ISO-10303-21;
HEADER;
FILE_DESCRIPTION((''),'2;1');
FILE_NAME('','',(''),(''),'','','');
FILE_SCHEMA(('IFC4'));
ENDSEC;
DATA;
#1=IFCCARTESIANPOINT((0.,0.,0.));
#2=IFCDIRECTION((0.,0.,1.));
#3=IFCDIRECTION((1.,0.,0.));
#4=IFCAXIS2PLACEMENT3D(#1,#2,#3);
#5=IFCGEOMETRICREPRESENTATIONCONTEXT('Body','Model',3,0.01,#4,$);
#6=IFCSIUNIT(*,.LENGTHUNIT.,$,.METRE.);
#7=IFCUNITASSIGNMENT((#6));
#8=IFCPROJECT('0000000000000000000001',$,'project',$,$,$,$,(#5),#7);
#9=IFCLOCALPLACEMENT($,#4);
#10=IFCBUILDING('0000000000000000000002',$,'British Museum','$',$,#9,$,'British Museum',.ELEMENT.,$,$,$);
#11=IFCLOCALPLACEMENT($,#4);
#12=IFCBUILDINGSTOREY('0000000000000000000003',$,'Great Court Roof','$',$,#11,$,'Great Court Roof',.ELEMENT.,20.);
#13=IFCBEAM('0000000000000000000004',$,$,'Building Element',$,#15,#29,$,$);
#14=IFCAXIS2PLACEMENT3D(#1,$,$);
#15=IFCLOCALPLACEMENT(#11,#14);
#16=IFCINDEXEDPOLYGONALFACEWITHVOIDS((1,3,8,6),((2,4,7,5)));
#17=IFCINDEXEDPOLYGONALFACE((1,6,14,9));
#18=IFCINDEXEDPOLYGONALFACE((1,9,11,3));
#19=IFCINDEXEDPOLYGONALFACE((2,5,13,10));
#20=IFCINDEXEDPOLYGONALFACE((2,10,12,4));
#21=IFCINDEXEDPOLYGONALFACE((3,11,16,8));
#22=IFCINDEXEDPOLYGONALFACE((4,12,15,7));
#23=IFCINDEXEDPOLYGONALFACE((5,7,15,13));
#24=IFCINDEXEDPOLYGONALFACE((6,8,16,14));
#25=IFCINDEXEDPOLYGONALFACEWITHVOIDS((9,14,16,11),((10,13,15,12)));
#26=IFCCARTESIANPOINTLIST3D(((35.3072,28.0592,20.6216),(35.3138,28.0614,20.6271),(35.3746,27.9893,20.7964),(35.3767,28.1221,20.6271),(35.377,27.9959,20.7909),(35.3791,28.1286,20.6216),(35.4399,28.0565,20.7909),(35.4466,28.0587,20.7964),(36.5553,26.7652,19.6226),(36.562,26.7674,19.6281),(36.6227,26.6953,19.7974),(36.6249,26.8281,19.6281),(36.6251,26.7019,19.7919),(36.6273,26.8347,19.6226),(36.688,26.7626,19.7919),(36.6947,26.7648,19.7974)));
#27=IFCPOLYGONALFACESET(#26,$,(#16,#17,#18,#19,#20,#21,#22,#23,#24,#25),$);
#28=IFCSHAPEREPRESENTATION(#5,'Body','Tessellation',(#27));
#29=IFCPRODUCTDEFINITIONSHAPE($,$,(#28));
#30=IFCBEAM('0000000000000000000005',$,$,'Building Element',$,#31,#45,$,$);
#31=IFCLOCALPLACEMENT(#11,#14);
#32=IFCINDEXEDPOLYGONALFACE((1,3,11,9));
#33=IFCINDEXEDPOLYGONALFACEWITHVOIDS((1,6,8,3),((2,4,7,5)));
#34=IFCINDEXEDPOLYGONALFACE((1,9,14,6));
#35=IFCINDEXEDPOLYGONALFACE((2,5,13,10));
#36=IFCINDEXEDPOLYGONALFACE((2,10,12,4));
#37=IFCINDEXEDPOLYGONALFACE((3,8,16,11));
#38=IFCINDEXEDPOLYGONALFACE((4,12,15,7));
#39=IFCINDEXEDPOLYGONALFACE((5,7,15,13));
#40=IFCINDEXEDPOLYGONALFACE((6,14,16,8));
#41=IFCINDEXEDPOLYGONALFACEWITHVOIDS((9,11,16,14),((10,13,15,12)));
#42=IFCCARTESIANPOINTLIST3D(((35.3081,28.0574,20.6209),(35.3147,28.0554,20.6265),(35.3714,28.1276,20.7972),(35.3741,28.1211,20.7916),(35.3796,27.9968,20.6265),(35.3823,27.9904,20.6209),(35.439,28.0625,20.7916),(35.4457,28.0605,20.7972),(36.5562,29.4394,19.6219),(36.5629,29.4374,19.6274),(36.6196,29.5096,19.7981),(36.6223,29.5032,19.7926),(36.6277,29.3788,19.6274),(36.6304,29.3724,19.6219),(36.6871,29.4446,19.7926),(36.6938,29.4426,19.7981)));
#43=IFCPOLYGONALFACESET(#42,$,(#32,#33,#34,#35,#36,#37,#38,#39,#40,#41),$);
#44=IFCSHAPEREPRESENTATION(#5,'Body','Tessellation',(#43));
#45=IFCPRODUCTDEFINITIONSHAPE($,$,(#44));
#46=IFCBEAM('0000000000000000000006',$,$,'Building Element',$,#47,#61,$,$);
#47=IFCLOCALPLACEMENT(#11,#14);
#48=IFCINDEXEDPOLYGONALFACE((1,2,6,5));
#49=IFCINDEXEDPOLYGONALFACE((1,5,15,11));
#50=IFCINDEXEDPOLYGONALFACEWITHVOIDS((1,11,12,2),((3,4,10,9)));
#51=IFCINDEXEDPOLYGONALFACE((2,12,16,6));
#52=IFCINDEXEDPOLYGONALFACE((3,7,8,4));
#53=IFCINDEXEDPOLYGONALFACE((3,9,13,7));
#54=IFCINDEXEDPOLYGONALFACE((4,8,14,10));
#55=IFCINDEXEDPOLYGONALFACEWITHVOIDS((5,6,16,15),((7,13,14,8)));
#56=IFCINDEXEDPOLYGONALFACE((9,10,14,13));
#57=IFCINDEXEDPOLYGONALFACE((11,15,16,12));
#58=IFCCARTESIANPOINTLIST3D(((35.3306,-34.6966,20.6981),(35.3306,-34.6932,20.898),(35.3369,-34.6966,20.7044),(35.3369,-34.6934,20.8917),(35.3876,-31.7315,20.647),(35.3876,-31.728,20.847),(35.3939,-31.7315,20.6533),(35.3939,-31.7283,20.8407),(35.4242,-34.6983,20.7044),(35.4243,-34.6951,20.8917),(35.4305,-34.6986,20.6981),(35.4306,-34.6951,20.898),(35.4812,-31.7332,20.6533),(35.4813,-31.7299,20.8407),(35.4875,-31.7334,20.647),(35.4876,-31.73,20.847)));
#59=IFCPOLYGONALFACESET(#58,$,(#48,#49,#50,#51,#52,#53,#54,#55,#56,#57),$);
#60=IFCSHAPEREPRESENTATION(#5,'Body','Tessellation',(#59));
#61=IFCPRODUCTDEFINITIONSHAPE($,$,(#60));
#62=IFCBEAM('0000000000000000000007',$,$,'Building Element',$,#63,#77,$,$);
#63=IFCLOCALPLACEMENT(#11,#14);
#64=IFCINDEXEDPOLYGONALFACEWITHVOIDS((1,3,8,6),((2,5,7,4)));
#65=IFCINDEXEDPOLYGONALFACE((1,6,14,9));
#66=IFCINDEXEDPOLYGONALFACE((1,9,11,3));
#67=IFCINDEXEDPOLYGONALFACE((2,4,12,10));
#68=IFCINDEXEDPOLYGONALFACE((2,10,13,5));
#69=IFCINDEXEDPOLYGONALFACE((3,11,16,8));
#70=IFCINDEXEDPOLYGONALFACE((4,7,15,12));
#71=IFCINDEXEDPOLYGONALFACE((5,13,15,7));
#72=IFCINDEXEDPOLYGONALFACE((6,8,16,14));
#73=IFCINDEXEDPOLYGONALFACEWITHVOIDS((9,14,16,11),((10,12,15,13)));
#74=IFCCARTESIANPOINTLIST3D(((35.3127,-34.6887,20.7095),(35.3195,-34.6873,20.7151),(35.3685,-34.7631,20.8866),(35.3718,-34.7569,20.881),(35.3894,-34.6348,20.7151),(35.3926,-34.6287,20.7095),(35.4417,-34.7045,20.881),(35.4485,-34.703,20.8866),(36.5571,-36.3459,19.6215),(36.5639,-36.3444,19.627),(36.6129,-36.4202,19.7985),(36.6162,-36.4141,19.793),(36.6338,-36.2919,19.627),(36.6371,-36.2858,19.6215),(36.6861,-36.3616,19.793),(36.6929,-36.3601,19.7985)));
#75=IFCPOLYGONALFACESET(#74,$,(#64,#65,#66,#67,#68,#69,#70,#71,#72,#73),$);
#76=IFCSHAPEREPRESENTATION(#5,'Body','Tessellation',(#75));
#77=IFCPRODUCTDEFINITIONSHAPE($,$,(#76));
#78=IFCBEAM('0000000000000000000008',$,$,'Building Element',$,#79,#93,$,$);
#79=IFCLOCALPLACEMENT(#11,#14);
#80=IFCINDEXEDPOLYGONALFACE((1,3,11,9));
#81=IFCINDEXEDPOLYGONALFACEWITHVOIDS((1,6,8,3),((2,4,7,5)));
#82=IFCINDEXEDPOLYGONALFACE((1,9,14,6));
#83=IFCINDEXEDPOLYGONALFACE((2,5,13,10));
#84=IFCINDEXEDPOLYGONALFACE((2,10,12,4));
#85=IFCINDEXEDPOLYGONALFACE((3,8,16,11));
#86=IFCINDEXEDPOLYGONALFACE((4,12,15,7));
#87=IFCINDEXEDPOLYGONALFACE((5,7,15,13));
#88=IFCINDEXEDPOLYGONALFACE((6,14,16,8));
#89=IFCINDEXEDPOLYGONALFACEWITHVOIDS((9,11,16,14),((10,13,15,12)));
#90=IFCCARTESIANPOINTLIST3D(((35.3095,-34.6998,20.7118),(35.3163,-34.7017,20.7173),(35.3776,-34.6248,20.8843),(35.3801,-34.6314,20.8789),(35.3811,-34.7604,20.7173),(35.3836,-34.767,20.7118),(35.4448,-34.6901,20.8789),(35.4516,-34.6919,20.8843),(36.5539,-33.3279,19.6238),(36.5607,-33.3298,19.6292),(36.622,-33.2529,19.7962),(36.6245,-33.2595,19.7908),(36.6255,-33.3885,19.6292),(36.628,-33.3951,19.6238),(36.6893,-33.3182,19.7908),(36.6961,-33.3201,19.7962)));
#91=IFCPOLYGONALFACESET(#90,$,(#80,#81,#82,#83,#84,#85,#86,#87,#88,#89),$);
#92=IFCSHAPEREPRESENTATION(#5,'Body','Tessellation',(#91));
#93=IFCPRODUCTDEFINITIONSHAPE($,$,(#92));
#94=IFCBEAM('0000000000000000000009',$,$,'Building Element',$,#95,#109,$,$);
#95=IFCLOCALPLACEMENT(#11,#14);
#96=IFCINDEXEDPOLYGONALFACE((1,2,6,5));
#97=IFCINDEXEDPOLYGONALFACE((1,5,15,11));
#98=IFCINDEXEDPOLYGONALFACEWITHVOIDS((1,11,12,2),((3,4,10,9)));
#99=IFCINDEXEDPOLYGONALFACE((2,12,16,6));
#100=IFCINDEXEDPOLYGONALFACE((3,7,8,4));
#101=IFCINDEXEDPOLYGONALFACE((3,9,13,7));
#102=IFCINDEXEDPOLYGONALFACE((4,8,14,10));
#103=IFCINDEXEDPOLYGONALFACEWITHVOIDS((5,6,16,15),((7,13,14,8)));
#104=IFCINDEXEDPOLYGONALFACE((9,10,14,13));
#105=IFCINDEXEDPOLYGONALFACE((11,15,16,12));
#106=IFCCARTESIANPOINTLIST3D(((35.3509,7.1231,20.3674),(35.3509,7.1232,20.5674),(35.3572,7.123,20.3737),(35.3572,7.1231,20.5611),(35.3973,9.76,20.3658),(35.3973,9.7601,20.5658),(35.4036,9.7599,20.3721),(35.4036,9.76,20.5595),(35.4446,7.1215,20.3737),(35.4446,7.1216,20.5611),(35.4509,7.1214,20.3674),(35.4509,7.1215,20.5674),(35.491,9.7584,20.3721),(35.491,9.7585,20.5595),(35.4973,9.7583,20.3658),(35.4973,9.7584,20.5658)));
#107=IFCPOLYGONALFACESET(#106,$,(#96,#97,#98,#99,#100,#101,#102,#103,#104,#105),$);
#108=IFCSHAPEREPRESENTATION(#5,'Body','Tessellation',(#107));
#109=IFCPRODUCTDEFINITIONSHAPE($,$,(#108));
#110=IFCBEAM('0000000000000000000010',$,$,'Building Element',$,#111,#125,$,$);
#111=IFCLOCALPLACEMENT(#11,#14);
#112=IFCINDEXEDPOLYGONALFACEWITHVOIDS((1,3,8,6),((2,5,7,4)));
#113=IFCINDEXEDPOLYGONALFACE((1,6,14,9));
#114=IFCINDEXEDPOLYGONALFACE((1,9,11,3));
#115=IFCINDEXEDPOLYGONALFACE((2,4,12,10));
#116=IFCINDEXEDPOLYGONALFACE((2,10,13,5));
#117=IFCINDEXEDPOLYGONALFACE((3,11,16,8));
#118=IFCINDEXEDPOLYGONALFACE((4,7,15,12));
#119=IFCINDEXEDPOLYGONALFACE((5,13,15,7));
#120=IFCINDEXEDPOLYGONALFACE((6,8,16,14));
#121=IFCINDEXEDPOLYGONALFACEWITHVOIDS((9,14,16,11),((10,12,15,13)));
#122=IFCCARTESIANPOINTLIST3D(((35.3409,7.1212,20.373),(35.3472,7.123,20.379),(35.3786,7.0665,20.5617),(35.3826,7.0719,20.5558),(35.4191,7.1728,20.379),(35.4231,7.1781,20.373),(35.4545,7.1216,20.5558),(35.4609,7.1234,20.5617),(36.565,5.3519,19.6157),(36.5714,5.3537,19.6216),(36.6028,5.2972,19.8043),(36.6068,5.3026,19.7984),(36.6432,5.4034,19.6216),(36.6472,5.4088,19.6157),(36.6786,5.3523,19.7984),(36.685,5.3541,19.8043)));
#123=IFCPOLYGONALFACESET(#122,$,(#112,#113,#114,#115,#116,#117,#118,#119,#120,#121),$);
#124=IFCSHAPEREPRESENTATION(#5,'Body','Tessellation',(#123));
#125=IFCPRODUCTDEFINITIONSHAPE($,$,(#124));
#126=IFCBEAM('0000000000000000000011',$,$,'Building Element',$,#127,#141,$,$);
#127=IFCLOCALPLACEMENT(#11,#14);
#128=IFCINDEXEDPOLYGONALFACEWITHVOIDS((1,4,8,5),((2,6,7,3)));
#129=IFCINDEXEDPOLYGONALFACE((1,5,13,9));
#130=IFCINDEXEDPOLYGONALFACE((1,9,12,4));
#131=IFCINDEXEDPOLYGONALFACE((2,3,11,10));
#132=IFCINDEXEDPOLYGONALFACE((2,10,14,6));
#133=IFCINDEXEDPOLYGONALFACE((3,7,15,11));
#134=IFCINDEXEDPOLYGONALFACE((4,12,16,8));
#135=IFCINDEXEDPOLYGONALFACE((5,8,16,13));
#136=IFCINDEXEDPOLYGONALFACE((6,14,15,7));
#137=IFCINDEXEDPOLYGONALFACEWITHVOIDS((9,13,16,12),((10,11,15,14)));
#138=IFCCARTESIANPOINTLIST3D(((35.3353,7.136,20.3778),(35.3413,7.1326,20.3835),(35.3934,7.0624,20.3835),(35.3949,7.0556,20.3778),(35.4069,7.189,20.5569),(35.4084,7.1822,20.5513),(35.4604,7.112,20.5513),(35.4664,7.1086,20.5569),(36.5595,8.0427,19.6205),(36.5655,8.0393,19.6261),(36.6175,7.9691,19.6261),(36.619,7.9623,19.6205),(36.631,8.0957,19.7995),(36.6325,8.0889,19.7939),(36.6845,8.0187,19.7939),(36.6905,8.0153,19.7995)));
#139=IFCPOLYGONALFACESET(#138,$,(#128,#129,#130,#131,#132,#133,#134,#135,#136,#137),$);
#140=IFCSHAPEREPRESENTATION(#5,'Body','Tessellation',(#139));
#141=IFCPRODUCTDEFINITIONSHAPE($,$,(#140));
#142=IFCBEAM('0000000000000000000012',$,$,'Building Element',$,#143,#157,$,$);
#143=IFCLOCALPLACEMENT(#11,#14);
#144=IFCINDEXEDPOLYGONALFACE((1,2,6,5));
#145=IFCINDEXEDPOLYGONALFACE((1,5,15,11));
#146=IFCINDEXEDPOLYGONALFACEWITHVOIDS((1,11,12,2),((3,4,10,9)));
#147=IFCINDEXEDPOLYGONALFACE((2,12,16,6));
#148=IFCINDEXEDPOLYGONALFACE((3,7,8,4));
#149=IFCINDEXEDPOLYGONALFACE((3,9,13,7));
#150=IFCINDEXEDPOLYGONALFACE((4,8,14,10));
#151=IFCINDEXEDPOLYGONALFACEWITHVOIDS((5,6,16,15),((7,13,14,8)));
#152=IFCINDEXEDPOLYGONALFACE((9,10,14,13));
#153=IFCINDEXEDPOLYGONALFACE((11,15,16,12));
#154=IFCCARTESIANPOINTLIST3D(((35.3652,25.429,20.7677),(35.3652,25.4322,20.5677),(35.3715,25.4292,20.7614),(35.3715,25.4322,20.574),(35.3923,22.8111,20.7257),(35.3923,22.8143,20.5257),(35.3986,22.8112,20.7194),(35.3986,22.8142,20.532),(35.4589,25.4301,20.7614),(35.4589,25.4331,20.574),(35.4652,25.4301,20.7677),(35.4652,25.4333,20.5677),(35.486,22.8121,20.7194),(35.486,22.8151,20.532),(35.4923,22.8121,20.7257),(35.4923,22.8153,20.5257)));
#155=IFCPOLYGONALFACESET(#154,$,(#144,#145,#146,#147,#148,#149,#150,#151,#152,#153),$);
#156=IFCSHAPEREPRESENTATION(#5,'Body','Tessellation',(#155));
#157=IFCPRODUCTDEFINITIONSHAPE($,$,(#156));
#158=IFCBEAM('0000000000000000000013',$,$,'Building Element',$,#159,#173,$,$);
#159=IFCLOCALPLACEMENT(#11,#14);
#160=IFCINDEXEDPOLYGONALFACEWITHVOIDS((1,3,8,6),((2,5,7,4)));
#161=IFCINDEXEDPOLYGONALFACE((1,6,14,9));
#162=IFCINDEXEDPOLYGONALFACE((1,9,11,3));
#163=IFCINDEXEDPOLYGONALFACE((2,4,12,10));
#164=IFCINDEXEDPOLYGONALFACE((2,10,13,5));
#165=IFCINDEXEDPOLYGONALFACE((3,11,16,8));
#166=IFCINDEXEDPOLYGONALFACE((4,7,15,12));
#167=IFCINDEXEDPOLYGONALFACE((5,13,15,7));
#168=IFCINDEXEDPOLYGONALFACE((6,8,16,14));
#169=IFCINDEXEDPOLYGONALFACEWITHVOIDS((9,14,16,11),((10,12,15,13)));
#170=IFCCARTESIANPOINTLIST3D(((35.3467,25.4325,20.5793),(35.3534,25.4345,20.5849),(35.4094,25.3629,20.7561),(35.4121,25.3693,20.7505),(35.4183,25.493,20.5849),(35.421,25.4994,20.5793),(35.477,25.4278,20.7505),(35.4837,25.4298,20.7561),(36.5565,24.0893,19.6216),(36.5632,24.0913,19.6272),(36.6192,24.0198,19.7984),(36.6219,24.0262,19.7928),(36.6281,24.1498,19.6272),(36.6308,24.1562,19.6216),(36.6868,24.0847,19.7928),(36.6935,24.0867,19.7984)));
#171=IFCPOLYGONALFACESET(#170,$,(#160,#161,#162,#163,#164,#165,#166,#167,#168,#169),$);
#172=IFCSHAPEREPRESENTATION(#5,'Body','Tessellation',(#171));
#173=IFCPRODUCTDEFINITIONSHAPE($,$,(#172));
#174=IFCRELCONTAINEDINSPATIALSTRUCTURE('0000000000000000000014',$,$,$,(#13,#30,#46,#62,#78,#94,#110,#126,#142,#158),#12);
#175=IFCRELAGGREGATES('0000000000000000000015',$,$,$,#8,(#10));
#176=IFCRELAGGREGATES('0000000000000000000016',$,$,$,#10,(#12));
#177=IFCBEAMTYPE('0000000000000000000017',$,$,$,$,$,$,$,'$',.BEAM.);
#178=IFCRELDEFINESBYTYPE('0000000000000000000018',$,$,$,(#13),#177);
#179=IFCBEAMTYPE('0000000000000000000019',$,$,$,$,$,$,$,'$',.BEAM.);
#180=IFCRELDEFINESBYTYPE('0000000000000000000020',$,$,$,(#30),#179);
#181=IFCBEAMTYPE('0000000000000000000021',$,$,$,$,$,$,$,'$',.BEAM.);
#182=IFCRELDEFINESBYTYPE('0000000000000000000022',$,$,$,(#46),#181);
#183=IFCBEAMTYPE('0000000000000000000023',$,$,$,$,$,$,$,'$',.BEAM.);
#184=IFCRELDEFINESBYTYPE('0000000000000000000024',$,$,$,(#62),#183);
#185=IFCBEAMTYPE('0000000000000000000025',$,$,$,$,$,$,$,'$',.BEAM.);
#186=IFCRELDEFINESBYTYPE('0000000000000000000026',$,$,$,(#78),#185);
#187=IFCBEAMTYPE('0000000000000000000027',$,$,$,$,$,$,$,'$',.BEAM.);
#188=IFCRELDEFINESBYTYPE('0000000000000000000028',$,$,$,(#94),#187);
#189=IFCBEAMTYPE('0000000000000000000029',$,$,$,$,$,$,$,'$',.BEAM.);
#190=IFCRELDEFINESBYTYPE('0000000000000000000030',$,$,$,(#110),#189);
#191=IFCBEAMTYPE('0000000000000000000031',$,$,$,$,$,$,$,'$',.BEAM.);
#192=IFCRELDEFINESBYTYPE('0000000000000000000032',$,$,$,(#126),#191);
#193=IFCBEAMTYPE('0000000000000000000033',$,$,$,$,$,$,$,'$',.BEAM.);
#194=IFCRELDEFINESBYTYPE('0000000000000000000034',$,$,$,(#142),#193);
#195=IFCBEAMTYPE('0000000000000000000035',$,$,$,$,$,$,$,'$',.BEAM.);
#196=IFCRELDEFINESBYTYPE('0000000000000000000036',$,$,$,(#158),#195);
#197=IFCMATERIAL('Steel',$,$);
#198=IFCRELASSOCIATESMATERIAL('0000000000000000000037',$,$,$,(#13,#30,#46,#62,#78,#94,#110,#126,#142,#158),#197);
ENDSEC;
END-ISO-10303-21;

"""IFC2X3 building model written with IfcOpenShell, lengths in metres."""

from ifc_helpers import new_model, si_unit, frame, origin_with_axes, origin_2d, place, context, project, spatial, hollow_rectangle, extrude, material, type_object, element, save


model = new_model("IFC2X3")

# Units and contexts
model_context = context("Model", 3, precision=0.01, world=origin_with_axes(), identifier="Body")
ifc_project = project(units=[si_unit("LENGTHUNIT", "METRE")], contexts=[model_context])

# Building, storey
building_placement = place(None, origin_with_axes())
building = spatial("IfcBuilding", under=ifc_project, at=building_placement, Name="British Museum", Description="$", LongName="British Museum", CompositionType="ELEMENT")
storey_placement = place(None, origin_with_axes())
storey = spatial("IfcBuildingStorey", under=building, at=storey_placement, Name="Great Court Roof", Description="$", LongName="Great Court Roof", CompositionType="ELEMENT", Elevation=20.0)

# Beams
ifc_material = material(Name="Steel")
beam_type_1 = type_object("IfcBeamType", ElementType="$", PredefinedType="BEAM")
beam_1_placement = place(None, origin_with_axes())
element("IfcBeam", 1, at=beam_1_placement, inside=storey, type_object=beam_type_1, material=ifc_material, Description="Building Element", context=model_context, shape_type="SweptSolid", body=[
    extrude(hollow_rectangle(XDim=0.1, YDim=0.2, WallThickness=0.0063, InnerFilletRadius=0.0, OuterFilletRadius=0.0, at=origin_2d()), frame((35.3769, 28.059, 20.709), z_axis=(0.606845, -0.629129, -0.485733), x_axis=(0.719738, 0.694245, 0.0)), (0.0, 0.0, 1.0), 2.0568),
])
beam_type_2 = type_object("IfcBeamType", ElementType="$", PredefinedType="BEAM")
beam_2_placement = place(None, origin_with_axes())
element("IfcBeam", 2, at=beam_2_placement, inside=storey, type_object=beam_type_2, material=ifc_material, Description="Building Element", context=model_context, shape_type="SweptSolid", body=[
    extrude(hollow_rectangle(XDim=0.1, YDim=0.2, WallThickness=0.0063, InnerFilletRadius=0.0, OuterFilletRadius=0.0, at=origin_2d()), frame((35.3769, 28.059, 20.709), z_axis=(0.590615, 0.65398, -0.472742), x_axis=(-0.742146, 0.670239, 0.0)), (0.0, 0.0, 1.0), 2.1133),
])
beam_type_3 = type_object("IfcBeamType", ElementType="$", PredefinedType="BEAM")
beam_3_placement = place(None, origin_with_axes())
element("IfcBeam", 3, at=beam_3_placement, inside=storey, type_object=beam_type_3, material=ifc_material, Description="Building Element", context=model_context, shape_type="SweptSolid", body=[
    extrude(hollow_rectangle(XDim=0.1, YDim=0.2, WallThickness=0.0063, InnerFilletRadius=0.0, OuterFilletRadius=0.0, at=origin_2d()), frame((35.3806, -34.6959, 20.7981), z_axis=(0.019218, 0.999667, -0.017217), x_axis=(-0.999815, 0.019221, 0.0)), (0.0, 0.0, 1.0), 2.9661),
])
beam_type_4 = type_object("IfcBeamType", ElementType="$", PredefinedType="BEAM")
beam_4_placement = place(None, origin_with_axes())
element("IfcBeam", 4, at=beam_4_placement, inside=storey, type_object=beam_type_4, material=ifc_material, Description="Building Element", context=model_context, shape_type="SweptSolid", body=[
    extrude(hollow_rectangle(XDim=0.1, YDim=0.2, WallThickness=0.0063, InnerFilletRadius=0.0, OuterFilletRadius=0.0, at=origin_2d()), frame((35.3806, -34.6959, 20.7981), z_axis=(0.531661, -0.707985, -0.46486), x_axis=(0.799636, 0.600486, 0.0)), (0.0, 0.0, 1.0), 2.3406),
])
beam_type_5 = type_object("IfcBeamType", ElementType="$", PredefinedType="BEAM")
beam_5_placement = place(None, origin_with_axes())
element("IfcBeam", 5, at=beam_5_placement, inside=storey, type_object=beam_type_5, material=ifc_material, Description="Building Element", context=model_context, shape_type="SweptSolid", body=[
    extrude(hollow_rectangle(XDim=0.1, YDim=0.2, WallThickness=0.0063, InnerFilletRadius=0.0, OuterFilletRadius=0.0, at=origin_2d()), frame((35.3806, -34.6959, 20.7981), z_axis=(0.579301, 0.638633, -0.506515), x_axis=(-0.740675, 0.671863, 0.0)), (0.0, 0.0, 1.0), 2.1481),
])
beam_type_6 = type_object("IfcBeamType", ElementType="$", PredefinedType="BEAM")
beam_6_placement = place(None, origin_with_axes())
element("IfcBeam", 6, at=beam_6_placement, inside=storey, type_object=beam_type_6, material=ifc_material, Description="Building Element", context=model_context, shape_type="SweptSolid", body=[
    extrude(hollow_rectangle(XDim=0.1, YDim=0.2, WallThickness=0.0063, InnerFilletRadius=0.0, OuterFilletRadius=0.0, at=origin_2d()), frame((35.4009, 7.1223, 20.4674), z_axis=(0.01761, 0.999845, -0.000584), x_axis=(-0.999845, 0.01761, 0.0)), (0.0, 0.0, 1.0), 2.6373),
])
beam_type_7 = type_object("IfcBeamType", ElementType="$", PredefinedType="BEAM")
beam_7_placement = place(None, origin_with_axes())
element("IfcBeam", 7, at=beam_7_placement, inside=storey, type_object=beam_type_7, material=ifc_material, Description="Building Element", context=model_context, shape_type="SweptSolid", body=[
    extrude(hollow_rectangle(XDim=0.1, YDim=0.2, WallThickness=0.0063, InnerFilletRadius=0.0, OuterFilletRadius=0.0, at=origin_2d()), frame((35.4009, 7.1223, 20.4674), z_axis=(0.536686, -0.775702, -0.332047), x_axis=(0.82236, 0.568967, 0.0)), (0.0, 0.0, 1.0), 2.2809),
])
beam_type_8 = type_object("IfcBeamType", ElementType="$", PredefinedType="BEAM")
beam_8_placement = place(None, origin_with_axes())
element("IfcBeam", 8, at=beam_8_placement, inside=storey, type_object=beam_type_8, material=ifc_material, Description="Building Element", context=model_context, shape_type="SweptSolid", body=[
    extrude(hollow_rectangle(XDim=0.1, YDim=0.2, WallThickness=0.0063, InnerFilletRadius=0.0, OuterFilletRadius=0.0, at=origin_2d()), frame((35.4009, 7.1223, 20.4674), z_axis=(0.719553, 0.532965, -0.445187), x_axis=(-0.5952, 0.803577, 0.0)), (0.0, 0.0, 1.0), 1.7012),
])
beam_type_9 = type_object("IfcBeamType", ElementType="$", PredefinedType="BEAM")
beam_9_placement = place(None, origin_with_axes())
element("IfcBeam", 9, at=beam_9_placement, inside=storey, type_object=beam_type_9, material=ifc_material, Description="Building Element", context=model_context, shape_type="SweptSolid", body=[
    extrude(hollow_rectangle(XDim=0.1, YDim=0.2, WallThickness=0.0063, InnerFilletRadius=0.0, OuterFilletRadius=0.0, at=origin_2d()), frame((35.4152, 25.4312, 20.6677), z_axis=(0.010342, -0.999818, -0.016049), x_axis=(0.999947, 0.010344, 0.0)), (0.0, 0.0, 1.0), 2.6184),
])
beam_type_10 = type_object("IfcBeamType", ElementType="$", PredefinedType="BEAM")
beam_10_placement = place(None, origin_with_axes())
element("IfcBeam", 10, at=beam_10_placement, inside=storey, type_object=beam_type_10, material=ifc_material, Description="Building Element", context=model_context, shape_type="SweptSolid", body=[
    extrude(hollow_rectangle(XDim=0.1, YDim=0.2, WallThickness=0.0063, InnerFilletRadius=0.0, OuterFilletRadius=0.0, at=origin_2d()), frame((35.4152, 25.4312, 20.6677), z_axis=(0.591388, -0.656577, -0.468153), x_axis=(0.74303, 0.669258, 0.0)), (0.0, 0.0, 1.0), 2.0457),
])

save(model, "model.ifc")
